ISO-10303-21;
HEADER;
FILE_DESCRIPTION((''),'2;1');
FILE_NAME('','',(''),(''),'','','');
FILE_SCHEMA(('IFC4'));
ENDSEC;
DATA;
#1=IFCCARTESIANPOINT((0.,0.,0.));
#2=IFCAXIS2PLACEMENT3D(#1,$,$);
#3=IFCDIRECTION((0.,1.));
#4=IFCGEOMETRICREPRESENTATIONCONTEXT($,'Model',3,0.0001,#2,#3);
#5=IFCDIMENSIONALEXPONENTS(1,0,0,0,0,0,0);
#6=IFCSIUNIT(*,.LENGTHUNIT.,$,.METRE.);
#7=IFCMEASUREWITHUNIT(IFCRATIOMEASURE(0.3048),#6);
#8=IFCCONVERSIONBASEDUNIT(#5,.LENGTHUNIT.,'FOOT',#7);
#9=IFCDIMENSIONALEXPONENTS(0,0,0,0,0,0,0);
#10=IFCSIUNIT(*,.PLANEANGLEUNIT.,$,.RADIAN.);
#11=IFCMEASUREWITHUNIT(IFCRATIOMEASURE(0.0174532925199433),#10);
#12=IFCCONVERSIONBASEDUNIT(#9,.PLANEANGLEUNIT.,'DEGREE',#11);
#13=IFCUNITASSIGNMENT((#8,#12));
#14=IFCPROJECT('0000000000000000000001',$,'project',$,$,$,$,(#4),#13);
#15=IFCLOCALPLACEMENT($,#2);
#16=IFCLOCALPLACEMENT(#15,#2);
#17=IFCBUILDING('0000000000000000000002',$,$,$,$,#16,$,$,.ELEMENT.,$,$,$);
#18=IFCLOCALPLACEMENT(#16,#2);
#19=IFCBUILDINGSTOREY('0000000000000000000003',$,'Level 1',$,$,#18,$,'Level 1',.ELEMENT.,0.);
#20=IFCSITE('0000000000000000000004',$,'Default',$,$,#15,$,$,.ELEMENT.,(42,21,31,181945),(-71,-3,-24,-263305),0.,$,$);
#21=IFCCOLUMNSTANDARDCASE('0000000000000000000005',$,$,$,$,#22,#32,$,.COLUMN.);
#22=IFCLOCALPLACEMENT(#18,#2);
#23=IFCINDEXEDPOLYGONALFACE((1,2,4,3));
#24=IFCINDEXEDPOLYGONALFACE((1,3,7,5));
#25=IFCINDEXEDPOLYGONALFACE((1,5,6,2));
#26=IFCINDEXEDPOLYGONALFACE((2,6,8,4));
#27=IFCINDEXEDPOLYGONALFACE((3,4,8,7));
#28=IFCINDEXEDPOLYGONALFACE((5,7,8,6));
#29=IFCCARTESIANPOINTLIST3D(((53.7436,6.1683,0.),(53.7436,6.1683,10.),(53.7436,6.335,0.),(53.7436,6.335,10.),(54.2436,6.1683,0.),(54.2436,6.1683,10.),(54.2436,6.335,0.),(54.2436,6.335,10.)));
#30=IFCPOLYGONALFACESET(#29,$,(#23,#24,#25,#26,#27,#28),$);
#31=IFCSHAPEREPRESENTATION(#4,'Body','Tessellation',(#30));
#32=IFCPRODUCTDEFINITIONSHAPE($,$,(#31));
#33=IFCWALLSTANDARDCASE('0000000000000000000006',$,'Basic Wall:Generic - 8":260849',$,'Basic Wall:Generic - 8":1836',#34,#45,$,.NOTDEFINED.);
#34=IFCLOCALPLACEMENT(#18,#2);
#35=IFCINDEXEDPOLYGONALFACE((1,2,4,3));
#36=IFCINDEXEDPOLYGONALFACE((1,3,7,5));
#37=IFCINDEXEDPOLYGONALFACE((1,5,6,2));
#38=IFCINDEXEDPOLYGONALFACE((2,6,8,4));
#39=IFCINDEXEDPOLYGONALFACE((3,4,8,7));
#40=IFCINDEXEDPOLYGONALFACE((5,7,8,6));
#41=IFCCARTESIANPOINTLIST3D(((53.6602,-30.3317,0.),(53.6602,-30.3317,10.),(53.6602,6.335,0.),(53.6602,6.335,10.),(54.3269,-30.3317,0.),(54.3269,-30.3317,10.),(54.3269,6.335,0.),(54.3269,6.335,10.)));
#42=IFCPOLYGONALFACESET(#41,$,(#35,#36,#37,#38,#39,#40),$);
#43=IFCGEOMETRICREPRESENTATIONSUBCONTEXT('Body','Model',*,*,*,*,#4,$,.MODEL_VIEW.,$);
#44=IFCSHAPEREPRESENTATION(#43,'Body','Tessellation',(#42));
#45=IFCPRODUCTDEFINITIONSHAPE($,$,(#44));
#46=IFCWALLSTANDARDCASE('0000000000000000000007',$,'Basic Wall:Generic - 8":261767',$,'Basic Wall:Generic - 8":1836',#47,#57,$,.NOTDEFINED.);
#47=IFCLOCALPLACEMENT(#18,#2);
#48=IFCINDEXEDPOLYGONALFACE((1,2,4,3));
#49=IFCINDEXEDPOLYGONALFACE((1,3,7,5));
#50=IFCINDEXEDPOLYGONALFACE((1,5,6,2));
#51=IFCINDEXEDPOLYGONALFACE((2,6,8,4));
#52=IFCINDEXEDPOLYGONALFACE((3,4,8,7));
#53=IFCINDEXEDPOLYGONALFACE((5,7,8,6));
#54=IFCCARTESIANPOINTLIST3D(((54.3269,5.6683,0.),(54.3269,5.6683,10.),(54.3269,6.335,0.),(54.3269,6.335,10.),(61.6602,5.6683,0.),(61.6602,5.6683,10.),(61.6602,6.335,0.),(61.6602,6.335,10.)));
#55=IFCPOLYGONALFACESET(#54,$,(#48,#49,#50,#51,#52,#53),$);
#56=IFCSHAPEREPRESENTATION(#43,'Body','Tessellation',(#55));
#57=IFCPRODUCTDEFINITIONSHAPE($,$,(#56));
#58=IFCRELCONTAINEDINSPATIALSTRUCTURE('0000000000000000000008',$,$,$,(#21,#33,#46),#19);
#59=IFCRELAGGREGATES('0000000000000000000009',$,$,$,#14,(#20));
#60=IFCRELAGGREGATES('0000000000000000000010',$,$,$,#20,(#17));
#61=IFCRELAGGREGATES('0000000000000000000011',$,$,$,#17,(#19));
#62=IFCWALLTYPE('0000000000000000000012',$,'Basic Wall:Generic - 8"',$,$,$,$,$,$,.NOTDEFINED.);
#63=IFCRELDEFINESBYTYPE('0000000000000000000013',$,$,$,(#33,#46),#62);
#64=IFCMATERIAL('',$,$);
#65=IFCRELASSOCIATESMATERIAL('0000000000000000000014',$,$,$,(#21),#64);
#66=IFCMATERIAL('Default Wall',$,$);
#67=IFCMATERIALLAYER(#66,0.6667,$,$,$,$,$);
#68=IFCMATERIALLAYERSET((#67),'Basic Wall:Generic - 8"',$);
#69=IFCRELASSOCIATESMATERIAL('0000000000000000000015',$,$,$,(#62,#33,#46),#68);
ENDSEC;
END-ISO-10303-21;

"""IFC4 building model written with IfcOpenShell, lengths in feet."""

from ifc_helpers import new_model, entity, si_unit, converted_unit, direction, frame, frame_2d, origin, place, context, subcontext, project, spatial, rectangle, extrude, material, layer, layer_set, layer_usage, type_object, element, save


model = new_model("IFC4")

# Units and contexts
model_context = context("Model", 3, precision=0.0001, world=origin(), true_north=direction((0.0, 1.0)))
body_context = subcontext(model_context, "Body", "Model", "MODEL_VIEW")
ifc_project = project(units=[converted_unit("LENGTHUNIT", "FOOT", entity("IfcRatioMeasure", 0.3048), si_unit("LENGTHUNIT", "METRE"), dimensions=[1, 0, 0, 0, 0, 0, 0]), converted_unit("PLANEANGLEUNIT", "DEGREE", entity("IfcRatioMeasure", 0.0174532925199433), si_unit("PLANEANGLEUNIT", "RADIAN"), dimensions=[0, 0, 0, 0, 0, 0, 0])], contexts=[model_context])

# Site, building, storey
site_placement = place(None, origin())
site = spatial("IfcSite", under=ifc_project, at=site_placement, Name="Default", CompositionType="ELEMENT", RefLatitude=(42, 21, 31, 181945), RefLongitude=(-71, -3, -24, -263305), RefElevation=0.0)
building_placement = place(site_placement, origin())
building = spatial("IfcBuilding", under=site, at=building_placement, CompositionType="ELEMENT")
storey_placement = place(building_placement, origin())
storey = spatial("IfcBuildingStorey", under=building, at=storey_placement, Name="Level 1", LongName="Level 1", CompositionType="ELEMENT", Elevation=0.0)

# Column
ifc_material_1 = material(Name="")
wall_1_placement = place(storey_placement, frame((53.9936, 6.335, 0.0), z_axis=(0.0, 0.0, 1.0), x_axis=(0.0, -1.0, 0.0)))
for number, where, z_axis, x_axis in (
    (1, (0.0833, 0.0, 0.0), (0.0, 0.0, 1.0), (1.0, 0.0, 0.0)),
):
    element("IfcColumnStandardCase", number, at=place(wall_1_placement, frame(where, z_axis=z_axis, x_axis=x_axis)), inside=storey, material=ifc_material_1, PredefinedType="COLUMN", context=model_context, shape_type="SweptSolid", body=[
        extrude(rectangle(XDim=0.1667, YDim=0.5), origin(), (0.0, 0.0, 1.0), 10.0),
    ])

# Walls
ifc_material_2 = material(Name="Default Wall")
ifc_layer = layer(ifc_material_2, 0.6667)
ifc_layer_set = layer_set([ifc_layer], Name="Basic Wall:Generic - 8\"")
ifc_layer_usage_1 = layer_usage(ifc_layer_set, "AXIS2", "NEGATIVE", 0.3333)
wall_type = type_object("IfcWallType", Name="Basic Wall:Generic - 8\"", PredefinedType="NOTDEFINED", material=ifc_layer_set)
element("IfcWallStandardCase", 2, at=wall_1_placement, inside=storey, type_object=wall_type, material=ifc_layer_usage_1, Name="Basic Wall:Generic - 8\":260849", ObjectType="Basic Wall:Generic - 8\":1836", PredefinedType="NOTDEFINED", context=body_context, shape_type="SweptSolid", body=[
    extrude(rectangle(XDim=36.6667, YDim=0.6667, at=frame_2d((18.3333, 0.0), x_axis=(-1.0, 0.0))), origin(), (0.0, 0.0, 1.0), 10.0),
])
ifc_layer_usage_2 = layer_usage(ifc_layer_set, "AXIS2", "NEGATIVE", 0.3333)
wall_2_placement = place(storey_placement, frame((54.3269, 6.0017, 0.0)))
element("IfcWallStandardCase", 3, at=wall_2_placement, inside=storey, type_object=wall_type, material=ifc_layer_usage_2, Name="Basic Wall:Generic - 8\":261767", ObjectType="Basic Wall:Generic - 8\":1836", PredefinedType="NOTDEFINED", context=body_context, shape_type="SweptSolid", body=[
    extrude(rectangle(XDim=7.3333, YDim=0.6667, at=frame_2d((3.6667, 0.0), x_axis=(-1.0, 0.0))), origin(), (0.0, 0.0, 1.0), 10.0),
])

save(model, "model.ifc")
